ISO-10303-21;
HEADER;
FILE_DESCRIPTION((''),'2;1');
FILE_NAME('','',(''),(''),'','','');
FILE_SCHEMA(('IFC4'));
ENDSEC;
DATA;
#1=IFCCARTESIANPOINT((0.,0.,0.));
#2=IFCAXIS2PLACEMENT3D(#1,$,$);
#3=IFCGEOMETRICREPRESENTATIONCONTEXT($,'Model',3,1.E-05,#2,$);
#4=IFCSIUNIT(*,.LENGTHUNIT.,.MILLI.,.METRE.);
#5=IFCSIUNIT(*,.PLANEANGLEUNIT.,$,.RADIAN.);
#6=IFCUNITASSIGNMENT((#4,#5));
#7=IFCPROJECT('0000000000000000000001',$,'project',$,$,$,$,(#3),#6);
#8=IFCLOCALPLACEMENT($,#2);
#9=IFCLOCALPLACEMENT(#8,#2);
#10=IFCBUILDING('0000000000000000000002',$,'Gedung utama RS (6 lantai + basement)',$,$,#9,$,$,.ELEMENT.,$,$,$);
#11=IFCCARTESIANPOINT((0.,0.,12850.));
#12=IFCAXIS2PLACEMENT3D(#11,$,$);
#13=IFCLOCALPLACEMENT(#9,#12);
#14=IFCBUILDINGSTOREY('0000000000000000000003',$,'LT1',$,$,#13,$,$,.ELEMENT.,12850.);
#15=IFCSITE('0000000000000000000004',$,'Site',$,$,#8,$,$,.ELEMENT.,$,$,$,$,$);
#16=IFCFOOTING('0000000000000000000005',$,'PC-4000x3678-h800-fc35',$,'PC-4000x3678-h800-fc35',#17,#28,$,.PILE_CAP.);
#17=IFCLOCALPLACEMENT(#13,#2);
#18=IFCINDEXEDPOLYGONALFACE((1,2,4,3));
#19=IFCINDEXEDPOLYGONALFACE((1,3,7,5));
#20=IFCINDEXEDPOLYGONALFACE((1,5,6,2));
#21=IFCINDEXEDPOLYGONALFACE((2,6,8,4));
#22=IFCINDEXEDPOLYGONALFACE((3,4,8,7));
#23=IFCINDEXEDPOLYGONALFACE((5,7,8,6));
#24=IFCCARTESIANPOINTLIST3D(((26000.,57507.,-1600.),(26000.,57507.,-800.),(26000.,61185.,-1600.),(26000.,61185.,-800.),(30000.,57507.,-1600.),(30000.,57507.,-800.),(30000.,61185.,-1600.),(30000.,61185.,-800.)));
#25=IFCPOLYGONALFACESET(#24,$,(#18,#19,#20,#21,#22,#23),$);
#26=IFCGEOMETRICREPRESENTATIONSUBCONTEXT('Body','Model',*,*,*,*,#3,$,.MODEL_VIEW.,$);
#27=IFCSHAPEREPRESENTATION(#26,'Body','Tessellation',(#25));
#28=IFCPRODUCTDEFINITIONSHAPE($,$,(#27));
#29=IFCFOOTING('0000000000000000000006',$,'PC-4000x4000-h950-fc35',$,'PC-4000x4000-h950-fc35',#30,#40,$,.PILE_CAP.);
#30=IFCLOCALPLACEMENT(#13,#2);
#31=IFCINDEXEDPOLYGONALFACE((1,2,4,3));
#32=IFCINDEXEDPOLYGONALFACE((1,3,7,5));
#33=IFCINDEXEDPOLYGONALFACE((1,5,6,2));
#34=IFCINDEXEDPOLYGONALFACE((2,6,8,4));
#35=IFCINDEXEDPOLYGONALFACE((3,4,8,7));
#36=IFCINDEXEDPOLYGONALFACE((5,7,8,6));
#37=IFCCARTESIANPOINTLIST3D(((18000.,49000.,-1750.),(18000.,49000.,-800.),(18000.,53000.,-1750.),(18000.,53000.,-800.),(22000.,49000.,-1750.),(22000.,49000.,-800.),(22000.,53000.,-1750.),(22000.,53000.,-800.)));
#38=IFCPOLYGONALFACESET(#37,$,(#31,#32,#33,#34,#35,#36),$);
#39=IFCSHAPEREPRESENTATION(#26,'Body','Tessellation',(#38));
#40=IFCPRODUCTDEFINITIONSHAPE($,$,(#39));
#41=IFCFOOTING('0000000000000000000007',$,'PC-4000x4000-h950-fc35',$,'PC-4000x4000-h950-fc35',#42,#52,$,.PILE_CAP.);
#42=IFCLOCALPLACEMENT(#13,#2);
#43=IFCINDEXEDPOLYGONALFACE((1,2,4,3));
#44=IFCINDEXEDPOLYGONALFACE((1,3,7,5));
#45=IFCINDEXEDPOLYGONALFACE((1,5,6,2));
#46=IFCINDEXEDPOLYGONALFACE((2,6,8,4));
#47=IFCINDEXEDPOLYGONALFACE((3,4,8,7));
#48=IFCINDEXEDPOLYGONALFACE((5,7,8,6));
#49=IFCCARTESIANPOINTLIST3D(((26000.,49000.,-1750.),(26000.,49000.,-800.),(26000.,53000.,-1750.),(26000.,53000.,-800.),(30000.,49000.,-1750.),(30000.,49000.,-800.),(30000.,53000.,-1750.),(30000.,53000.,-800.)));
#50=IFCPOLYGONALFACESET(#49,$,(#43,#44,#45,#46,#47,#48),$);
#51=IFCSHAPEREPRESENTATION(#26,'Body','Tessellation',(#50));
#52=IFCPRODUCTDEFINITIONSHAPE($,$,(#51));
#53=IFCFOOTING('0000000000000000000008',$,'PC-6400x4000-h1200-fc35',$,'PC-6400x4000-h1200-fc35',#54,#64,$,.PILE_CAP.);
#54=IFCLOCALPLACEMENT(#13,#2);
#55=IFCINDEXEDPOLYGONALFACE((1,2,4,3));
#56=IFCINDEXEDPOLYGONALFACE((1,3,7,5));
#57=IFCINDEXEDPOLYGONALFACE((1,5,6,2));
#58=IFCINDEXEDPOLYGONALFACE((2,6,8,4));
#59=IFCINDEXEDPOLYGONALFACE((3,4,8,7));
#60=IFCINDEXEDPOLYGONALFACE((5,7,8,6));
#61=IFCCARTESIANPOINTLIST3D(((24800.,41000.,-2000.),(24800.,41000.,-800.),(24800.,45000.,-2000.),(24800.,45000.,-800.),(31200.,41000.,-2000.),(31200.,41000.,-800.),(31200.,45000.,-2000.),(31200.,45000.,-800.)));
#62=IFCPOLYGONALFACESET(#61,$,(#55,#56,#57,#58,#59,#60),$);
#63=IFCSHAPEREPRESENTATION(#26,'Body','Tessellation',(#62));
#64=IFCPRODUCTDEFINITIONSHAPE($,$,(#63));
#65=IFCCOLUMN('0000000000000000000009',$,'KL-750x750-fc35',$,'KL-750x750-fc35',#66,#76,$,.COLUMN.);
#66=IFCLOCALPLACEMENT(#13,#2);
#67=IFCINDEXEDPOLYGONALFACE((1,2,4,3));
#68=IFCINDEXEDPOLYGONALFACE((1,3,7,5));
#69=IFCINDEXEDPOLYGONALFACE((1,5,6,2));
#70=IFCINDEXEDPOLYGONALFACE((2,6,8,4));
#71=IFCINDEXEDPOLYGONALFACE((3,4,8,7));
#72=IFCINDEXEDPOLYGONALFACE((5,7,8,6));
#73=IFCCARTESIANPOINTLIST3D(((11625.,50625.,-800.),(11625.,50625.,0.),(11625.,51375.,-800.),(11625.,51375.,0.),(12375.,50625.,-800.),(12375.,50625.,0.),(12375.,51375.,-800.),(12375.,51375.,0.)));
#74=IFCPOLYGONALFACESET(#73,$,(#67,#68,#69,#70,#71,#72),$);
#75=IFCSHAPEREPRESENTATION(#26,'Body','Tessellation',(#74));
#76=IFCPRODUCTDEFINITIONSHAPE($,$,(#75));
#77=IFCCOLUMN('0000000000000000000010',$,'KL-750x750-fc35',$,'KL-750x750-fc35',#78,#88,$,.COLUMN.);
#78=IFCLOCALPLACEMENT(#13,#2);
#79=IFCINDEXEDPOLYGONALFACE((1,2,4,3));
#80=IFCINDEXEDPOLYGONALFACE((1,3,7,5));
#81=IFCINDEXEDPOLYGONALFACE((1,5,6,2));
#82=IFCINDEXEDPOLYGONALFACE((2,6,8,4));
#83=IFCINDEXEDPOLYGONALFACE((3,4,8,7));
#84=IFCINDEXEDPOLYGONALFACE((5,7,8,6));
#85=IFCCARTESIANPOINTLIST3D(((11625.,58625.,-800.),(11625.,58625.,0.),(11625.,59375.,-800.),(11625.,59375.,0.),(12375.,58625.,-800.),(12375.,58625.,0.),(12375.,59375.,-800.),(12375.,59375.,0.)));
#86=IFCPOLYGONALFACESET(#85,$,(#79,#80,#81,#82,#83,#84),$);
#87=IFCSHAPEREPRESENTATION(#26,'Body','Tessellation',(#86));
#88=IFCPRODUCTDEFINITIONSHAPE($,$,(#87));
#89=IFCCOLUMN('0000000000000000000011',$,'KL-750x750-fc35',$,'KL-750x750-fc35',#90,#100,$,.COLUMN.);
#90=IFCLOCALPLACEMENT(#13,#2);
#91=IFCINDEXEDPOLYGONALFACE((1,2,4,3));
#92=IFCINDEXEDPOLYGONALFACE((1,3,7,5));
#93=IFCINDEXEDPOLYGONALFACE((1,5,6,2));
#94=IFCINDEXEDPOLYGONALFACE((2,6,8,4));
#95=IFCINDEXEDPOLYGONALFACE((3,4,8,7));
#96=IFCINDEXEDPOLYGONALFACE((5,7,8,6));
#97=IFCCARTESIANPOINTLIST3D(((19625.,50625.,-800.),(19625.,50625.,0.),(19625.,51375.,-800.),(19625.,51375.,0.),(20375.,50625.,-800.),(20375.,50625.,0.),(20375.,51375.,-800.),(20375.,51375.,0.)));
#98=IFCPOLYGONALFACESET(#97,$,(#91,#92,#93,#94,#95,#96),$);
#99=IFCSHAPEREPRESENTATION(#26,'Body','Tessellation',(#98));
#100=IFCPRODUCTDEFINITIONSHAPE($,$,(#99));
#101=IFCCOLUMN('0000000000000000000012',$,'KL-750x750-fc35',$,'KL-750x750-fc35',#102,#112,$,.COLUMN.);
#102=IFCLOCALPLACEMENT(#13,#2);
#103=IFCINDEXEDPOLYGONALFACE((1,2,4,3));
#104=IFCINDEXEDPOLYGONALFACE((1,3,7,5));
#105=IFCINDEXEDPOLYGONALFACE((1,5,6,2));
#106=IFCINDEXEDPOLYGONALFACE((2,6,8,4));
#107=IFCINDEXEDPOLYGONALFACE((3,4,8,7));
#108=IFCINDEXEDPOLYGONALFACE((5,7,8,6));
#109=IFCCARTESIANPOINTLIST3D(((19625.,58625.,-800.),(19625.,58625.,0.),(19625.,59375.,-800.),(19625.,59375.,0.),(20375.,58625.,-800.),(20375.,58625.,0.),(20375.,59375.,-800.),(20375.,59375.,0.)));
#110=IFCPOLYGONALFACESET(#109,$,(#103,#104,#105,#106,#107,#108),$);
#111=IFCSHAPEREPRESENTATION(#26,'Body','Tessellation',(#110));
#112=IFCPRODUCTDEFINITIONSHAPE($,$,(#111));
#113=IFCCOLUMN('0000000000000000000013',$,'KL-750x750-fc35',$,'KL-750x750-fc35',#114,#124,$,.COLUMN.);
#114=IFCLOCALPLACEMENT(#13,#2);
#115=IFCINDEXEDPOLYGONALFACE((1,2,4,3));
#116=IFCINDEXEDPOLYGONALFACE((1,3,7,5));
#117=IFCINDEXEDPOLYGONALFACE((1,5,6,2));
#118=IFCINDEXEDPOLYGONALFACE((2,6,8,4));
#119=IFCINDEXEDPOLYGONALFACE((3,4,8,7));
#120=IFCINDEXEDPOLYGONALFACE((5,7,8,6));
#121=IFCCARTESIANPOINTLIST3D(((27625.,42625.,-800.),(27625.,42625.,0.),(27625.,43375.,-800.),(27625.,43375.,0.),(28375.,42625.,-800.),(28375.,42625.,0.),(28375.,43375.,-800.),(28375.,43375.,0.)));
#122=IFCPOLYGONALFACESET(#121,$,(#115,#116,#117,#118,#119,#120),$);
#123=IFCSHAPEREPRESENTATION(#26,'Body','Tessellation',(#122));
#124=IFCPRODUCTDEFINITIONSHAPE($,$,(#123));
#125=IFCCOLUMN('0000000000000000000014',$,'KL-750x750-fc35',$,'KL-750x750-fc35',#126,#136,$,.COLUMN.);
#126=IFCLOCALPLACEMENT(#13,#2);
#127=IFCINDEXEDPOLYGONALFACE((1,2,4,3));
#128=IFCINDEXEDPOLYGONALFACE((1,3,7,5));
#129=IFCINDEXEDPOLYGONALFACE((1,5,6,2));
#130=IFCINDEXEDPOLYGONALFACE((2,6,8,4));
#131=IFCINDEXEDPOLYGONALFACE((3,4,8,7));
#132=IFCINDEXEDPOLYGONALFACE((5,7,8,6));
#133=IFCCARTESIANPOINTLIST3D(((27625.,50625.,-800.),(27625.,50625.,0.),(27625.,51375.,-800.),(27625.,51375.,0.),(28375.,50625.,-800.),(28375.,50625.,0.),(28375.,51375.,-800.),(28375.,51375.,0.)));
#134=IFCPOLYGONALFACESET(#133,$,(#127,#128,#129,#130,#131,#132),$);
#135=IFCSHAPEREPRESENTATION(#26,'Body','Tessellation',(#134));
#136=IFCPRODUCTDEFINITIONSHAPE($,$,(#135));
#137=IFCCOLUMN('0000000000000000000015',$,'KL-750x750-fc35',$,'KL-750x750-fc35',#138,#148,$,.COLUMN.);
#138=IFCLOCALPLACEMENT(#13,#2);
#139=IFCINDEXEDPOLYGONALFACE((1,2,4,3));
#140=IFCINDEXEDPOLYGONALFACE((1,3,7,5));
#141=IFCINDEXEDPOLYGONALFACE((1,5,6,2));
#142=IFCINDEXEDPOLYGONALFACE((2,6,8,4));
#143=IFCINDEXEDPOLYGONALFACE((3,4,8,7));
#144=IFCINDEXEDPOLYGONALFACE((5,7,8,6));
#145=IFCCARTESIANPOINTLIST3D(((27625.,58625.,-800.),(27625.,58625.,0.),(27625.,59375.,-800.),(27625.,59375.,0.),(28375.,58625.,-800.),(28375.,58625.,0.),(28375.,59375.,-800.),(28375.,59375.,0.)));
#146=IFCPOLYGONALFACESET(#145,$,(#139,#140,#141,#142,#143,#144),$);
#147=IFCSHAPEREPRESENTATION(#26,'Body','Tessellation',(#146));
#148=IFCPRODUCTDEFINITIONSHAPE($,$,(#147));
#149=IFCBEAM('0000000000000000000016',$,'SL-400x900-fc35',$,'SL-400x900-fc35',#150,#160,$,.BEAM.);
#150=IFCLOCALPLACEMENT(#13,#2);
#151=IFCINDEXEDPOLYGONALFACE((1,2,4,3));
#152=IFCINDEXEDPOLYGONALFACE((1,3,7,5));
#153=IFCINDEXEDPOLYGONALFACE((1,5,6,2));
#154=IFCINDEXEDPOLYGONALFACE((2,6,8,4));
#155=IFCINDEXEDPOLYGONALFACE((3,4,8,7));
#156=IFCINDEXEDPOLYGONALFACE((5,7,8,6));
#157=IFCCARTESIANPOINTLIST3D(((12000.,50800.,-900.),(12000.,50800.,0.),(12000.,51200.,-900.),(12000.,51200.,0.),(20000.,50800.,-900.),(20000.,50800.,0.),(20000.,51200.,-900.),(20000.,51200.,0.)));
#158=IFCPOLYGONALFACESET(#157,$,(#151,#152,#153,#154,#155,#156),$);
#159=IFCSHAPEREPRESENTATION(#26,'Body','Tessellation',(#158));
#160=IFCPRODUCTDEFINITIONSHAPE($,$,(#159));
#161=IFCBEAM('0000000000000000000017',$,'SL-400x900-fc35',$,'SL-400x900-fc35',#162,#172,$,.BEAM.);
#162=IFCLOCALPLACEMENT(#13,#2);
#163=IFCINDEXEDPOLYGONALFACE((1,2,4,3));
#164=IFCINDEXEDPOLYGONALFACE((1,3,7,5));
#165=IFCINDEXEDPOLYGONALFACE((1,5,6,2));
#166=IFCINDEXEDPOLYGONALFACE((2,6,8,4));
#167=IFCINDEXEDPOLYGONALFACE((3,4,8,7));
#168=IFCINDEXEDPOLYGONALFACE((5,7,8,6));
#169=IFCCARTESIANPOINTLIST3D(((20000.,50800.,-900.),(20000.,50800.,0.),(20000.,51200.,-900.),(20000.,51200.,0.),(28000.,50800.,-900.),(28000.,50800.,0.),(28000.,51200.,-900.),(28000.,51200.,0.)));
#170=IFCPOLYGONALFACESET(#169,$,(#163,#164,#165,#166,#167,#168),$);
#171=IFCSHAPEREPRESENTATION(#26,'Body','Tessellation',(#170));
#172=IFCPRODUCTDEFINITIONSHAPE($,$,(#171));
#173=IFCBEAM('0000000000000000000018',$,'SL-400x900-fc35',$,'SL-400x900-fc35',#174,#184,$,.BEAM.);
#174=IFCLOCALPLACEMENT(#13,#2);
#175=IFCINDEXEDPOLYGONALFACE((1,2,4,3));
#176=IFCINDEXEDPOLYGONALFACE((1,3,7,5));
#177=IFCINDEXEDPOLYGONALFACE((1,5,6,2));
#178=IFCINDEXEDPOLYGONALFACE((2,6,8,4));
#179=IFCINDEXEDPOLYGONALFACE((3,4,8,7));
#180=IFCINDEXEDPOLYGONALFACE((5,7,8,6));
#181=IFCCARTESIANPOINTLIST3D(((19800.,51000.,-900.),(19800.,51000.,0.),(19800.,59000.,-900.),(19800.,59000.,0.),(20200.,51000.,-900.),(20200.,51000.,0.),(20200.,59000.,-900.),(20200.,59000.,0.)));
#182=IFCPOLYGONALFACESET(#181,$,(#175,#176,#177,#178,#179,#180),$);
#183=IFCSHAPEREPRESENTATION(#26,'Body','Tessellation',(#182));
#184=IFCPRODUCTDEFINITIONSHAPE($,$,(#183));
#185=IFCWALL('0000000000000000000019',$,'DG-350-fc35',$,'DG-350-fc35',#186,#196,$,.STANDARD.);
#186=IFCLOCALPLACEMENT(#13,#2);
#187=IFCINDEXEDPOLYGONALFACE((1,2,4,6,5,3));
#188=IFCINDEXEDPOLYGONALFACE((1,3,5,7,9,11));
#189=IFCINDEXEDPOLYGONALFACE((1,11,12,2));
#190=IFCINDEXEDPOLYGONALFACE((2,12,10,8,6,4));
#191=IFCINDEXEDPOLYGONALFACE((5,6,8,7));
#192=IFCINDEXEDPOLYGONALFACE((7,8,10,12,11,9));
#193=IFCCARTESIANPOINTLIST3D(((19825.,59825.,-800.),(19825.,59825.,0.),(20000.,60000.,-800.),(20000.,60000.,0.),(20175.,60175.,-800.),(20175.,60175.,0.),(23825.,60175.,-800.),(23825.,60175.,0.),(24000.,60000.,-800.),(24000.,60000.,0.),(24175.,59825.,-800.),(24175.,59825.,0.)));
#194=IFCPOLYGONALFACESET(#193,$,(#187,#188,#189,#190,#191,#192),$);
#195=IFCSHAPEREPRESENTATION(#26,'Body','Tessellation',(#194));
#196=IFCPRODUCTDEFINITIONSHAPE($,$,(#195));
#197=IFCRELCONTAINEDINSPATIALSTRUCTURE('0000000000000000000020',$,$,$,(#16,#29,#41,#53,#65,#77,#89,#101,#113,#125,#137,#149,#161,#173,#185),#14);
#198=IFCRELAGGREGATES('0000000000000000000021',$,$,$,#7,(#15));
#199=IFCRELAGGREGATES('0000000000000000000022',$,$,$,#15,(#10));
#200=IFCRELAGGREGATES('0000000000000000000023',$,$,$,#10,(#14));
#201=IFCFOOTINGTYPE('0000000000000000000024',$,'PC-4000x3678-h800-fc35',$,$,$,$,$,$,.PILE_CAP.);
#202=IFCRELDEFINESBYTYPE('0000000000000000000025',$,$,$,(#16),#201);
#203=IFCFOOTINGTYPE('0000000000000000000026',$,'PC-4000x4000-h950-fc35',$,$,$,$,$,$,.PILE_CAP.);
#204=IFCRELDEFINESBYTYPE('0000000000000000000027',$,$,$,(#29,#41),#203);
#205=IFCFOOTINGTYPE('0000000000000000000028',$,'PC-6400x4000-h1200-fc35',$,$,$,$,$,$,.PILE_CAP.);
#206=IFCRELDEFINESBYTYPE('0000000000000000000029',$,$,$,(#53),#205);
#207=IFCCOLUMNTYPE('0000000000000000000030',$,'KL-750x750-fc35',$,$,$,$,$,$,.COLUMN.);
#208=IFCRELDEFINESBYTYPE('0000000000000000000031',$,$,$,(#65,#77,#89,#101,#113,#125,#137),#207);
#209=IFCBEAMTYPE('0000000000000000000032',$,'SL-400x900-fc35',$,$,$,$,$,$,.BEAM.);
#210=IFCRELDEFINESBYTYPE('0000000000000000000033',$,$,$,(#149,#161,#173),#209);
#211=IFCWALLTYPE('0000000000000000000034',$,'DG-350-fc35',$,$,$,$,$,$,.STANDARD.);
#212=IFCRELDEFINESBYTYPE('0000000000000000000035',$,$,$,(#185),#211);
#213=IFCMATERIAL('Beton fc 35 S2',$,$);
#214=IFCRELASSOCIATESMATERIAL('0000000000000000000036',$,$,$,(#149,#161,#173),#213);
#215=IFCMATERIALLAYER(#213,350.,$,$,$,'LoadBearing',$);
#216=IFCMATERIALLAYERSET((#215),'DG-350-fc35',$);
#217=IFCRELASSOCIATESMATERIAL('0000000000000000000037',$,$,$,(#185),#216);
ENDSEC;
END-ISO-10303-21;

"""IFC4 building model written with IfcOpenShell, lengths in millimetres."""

from ifc_helpers import new_model, si_unit, frame, origin, origin_2d, place, context, subcontext, project, spatial, polyline, rectangle, outline, extrude, material, layer, layer_set, layer_usage, material_profile, profile_set, profile_usage, type_object, element, save


model = new_model("IFC4")

# Units and contexts
model_context = context("Model", 3, precision=1e-05, world=origin())
body_context = subcontext(model_context, "Body", "Model", "MODEL_VIEW")
ifc_project = project(units=[si_unit("LENGTHUNIT", "METRE", prefix="MILLI"), si_unit("PLANEANGLEUNIT", "RADIAN")], contexts=[model_context])

# Site, building, storey
site_placement = place(None, origin())
site = spatial("IfcSite", under=ifc_project, at=site_placement, Name="Site", CompositionType="ELEMENT")
building_placement = place(site_placement, origin())
building = spatial("IfcBuilding", under=site, at=building_placement, Name="Gedung utama RS (6 lantai + basement)", CompositionType="ELEMENT")
storey_placement = place(building_placement, frame((0.0, 0.0, 12850.0)))
storey = spatial("IfcBuildingStorey", under=building, at=storey_placement, Name="LT1", CompositionType="ELEMENT", Elevation=12850.0)

# Footings
ifc_material_profile_1 = material_profile(None, rectangle(XDim=4000.0, YDim=3678.0, at=origin_2d()), Name="PC-4000x3678-h800-fc35")
ifc_profile_set_1 = profile_set([ifc_material_profile_1], Name="PC-4000x3678-h800-fc35")
ifc_profile_usage_1 = profile_usage(ifc_profile_set_1, cardinal=5)
footing_type_1 = type_object("IfcFootingType", Name="PC-4000x3678-h800-fc35", PredefinedType="PILE_CAP")
footing_1_placement = place(storey_placement, frame((28000.0, 59346.0, -1600.0), z_axis=(0.0, 0.0, 1.0), x_axis=(1.0, 0.0, 0.0)))
element("IfcFooting", 1, at=footing_1_placement, inside=storey, type_object=footing_type_1, material=ifc_profile_usage_1, Name="PC-4000x3678-h800-fc35", ObjectType="PC-4000x3678-h800-fc35", PredefinedType="PILE_CAP", context=body_context, shape_type="SweptSolid", body=[
    extrude(rectangle(XDim=4000.0, YDim=3678.0, at=origin_2d()), origin(), (0.0, 0.0, 1.0), 800.0),
])
ifc_material_profile_2 = material_profile(None, rectangle(XDim=4000.0, YDim=4000.0, at=origin_2d()), Name="PC-4000x4000-h950-fc35")
ifc_profile_set_2 = profile_set([ifc_material_profile_2], Name="PC-4000x4000-h950-fc35")
ifc_profile_usage_2 = profile_usage(ifc_profile_set_2, cardinal=5)
footing_type_2 = type_object("IfcFootingType", Name="PC-4000x4000-h950-fc35", PredefinedType="PILE_CAP")
for number, where, z_axis, x_axis, name in (
    (2, (20000.0, 51000.0, -1750.0), (0.0, 0.0, 1.0), (1.0, 0.0, 0.0), "PC-4000x4000-h950-fc35"),
    (3, (28000.0, 51000.0, -1750.0), (0.0, 0.0, 1.0), (1.0, 0.0, 0.0), "PC-4000x4000-h950-fc35"),
):
    element("IfcFooting", number, at=place(storey_placement, frame(where, z_axis=z_axis, x_axis=x_axis)), inside=storey, type_object=footing_type_2, material=ifc_profile_usage_2, Name=name, ObjectType="PC-4000x4000-h950-fc35", PredefinedType="PILE_CAP", context=body_context, shape_type="SweptSolid", body=[
        extrude(rectangle(XDim=4000.0, YDim=4000.0, at=origin_2d()), origin(), (0.0, 0.0, 1.0), 950.0),
    ])
ifc_material_profile_3 = material_profile(None, rectangle(XDim=6400.0, YDim=4000.0, at=origin_2d()), Name="PC-6400x4000-h1200-fc35")
ifc_profile_set_3 = profile_set([ifc_material_profile_3], Name="PC-6400x4000-h1200-fc35")
ifc_profile_usage_3 = profile_usage(ifc_profile_set_3, cardinal=5)
footing_type_3 = type_object("IfcFootingType", Name="PC-6400x4000-h1200-fc35", PredefinedType="PILE_CAP")
footing_2_placement = place(storey_placement, frame((28000.0, 43000.0, -2000.0), z_axis=(0.0, 0.0, 1.0), x_axis=(1.0, 0.0, 0.0)))
element("IfcFooting", 4, at=footing_2_placement, inside=storey, type_object=footing_type_3, material=ifc_profile_usage_3, Name="PC-6400x4000-h1200-fc35", ObjectType="PC-6400x4000-h1200-fc35", PredefinedType="PILE_CAP", context=body_context, shape_type="SweptSolid", body=[
    extrude(rectangle(XDim=6400.0, YDim=4000.0, at=origin_2d()), origin(), (0.0, 0.0, 1.0), 1200.0),
])

# Columns
ifc_material_profile_4 = material_profile(None, rectangle(XDim=750.0, YDim=750.0, at=origin_2d()), Name="KL-750x750-fc35")
ifc_profile_set_4 = profile_set([ifc_material_profile_4], Name="KL-750x750-fc35")
ifc_profile_usage_4 = profile_usage(ifc_profile_set_4, cardinal=5)
column_type = type_object("IfcColumnType", Name="KL-750x750-fc35", PredefinedType="COLUMN")
for number, where, z_axis, x_axis, name in (
    (5, (12000.0, 51000.0, -800.0), (0.0, 0.0, 1.0), (1.0, 0.0, 0.0), "KL-750x750-fc35"),
    (6, (12000.0, 59000.0, -800.0), (0.0, 0.0, 1.0), (1.0, 0.0, 0.0), "KL-750x750-fc35"),
    (7, (20000.0, 51000.0, -800.0), (0.0, 0.0, 1.0), (1.0, 0.0, 0.0), "KL-750x750-fc35"),
    (8, (20000.0, 59000.0, -800.0), (0.0, 0.0, 1.0), (1.0, 0.0, 0.0), "KL-750x750-fc35"),
    (9, (28000.0, 43000.0, -800.0), (0.0, 0.0, 1.0), (1.0, 0.0, 0.0), "KL-750x750-fc35"),
    (10, (28000.0, 51000.0, -800.0), (0.0, 0.0, 1.0), (1.0, 0.0, 0.0), "KL-750x750-fc35"),
    (11, (28000.0, 59000.0, -800.0), (0.0, 0.0, 1.0), (1.0, 0.0, 0.0), "KL-750x750-fc35"),
):
    element("IfcColumn", number, at=place(storey_placement, frame(where, z_axis=z_axis, x_axis=x_axis)), inside=storey, type_object=column_type, material=ifc_profile_usage_4, Name=name, ObjectType="KL-750x750-fc35", PredefinedType="COLUMN", context=body_context, shape_type="SweptSolid", body=[
        extrude(rectangle(XDim=750.0, YDim=750.0, at=origin_2d()), origin(), (0.0, 0.0, 1.0), 800.0),
    ])

# Beams
ifc_material = material(Name="Beton fc 35 S2")
ifc_material_profile_5 = material_profile(ifc_material, rectangle(XDim=400.0, YDim=900.0, at=origin_2d()), Name="SL-400x900-fc35")
ifc_profile_set_5 = profile_set([ifc_material_profile_5], Name="SL-400x900-fc35")
ifc_profile_usage_5 = profile_usage(ifc_profile_set_5, cardinal=8)
beam_type = type_object("IfcBeamType", Name="SL-400x900-fc35", PredefinedType="BEAM")
for number, where, name in (
    (12, (12000.0, 51000.0, -450.0), "SL-400x900-fc35"),
    (13, (20000.0, 51000.0, -450.0), "SL-400x900-fc35"),
):
    element("IfcBeam", number, at=place(storey_placement, frame(where)), inside=storey, type_object=beam_type, material=ifc_profile_usage_5, Name=name, ObjectType="SL-400x900-fc35", PredefinedType="BEAM", context=body_context, shape_type="SweptSolid", body=[
        extrude(rectangle(XDim=400.0, YDim=900.0, at=origin_2d()), frame((0.0, 0.0, 0.0), z_axis=(1.0, 0.0, 0.0), x_axis=(0.0, 1.0, 0.0)), (0.0, 0.0, 1.0), 8000.0),
    ])
beam_placement = place(storey_placement, frame((20000.0, 51000.0, -450.0)))
element("IfcBeam", 14, at=beam_placement, inside=storey, type_object=beam_type, material=ifc_profile_usage_5, Name="SL-400x900-fc35", ObjectType="SL-400x900-fc35", PredefinedType="BEAM", context=body_context, shape_type="SweptSolid", body=[
    extrude(rectangle(XDim=400.0, YDim=900.0, at=origin_2d()), frame((0.0, 0.0, 0.0), z_axis=(0.0, 1.0, 0.0), x_axis=(-1.0, 0.0, 0.0)), (0.0, 0.0, 1.0), 8000.0),
])

# Wall
ifc_layer = layer(ifc_material, 350.0, Category="LoadBearing")
ifc_layer_set = layer_set([ifc_layer], Name="DG-350-fc35")
ifc_layer_usage = layer_usage(ifc_layer_set, "AXIS2", "NEGATIVE", 175.0)
wall_type = type_object("IfcWallType", Name="DG-350-fc35", PredefinedType="STANDARD")
wall_1_placement = place(storey_placement, frame((20000.0, 60000.0, -800.0), z_axis=(0.0, 0.0, 1.0), x_axis=(1.0, 0.0, 0.0)))
element("IfcWall", 15, at=wall_1_placement, inside=storey, type_object=wall_type, material=ifc_layer_usage, Name="DG-350-fc35", ObjectType="DG-350-fc35", PredefinedType="STANDARD", context=body_context, shape_type="SweptSolid", body=[
    extrude(outline(polyline([(-175.0, -175.0), (0.0, 0.0), (175.0, 175.0), (3825.0, 175.0), (4000.0, 0.0), (4175.0, -175.0), (-175.0, -175.0)])), origin(), (0.0, 0.0, 1.0), 800.0),
])

save(model, "model.ifc")
